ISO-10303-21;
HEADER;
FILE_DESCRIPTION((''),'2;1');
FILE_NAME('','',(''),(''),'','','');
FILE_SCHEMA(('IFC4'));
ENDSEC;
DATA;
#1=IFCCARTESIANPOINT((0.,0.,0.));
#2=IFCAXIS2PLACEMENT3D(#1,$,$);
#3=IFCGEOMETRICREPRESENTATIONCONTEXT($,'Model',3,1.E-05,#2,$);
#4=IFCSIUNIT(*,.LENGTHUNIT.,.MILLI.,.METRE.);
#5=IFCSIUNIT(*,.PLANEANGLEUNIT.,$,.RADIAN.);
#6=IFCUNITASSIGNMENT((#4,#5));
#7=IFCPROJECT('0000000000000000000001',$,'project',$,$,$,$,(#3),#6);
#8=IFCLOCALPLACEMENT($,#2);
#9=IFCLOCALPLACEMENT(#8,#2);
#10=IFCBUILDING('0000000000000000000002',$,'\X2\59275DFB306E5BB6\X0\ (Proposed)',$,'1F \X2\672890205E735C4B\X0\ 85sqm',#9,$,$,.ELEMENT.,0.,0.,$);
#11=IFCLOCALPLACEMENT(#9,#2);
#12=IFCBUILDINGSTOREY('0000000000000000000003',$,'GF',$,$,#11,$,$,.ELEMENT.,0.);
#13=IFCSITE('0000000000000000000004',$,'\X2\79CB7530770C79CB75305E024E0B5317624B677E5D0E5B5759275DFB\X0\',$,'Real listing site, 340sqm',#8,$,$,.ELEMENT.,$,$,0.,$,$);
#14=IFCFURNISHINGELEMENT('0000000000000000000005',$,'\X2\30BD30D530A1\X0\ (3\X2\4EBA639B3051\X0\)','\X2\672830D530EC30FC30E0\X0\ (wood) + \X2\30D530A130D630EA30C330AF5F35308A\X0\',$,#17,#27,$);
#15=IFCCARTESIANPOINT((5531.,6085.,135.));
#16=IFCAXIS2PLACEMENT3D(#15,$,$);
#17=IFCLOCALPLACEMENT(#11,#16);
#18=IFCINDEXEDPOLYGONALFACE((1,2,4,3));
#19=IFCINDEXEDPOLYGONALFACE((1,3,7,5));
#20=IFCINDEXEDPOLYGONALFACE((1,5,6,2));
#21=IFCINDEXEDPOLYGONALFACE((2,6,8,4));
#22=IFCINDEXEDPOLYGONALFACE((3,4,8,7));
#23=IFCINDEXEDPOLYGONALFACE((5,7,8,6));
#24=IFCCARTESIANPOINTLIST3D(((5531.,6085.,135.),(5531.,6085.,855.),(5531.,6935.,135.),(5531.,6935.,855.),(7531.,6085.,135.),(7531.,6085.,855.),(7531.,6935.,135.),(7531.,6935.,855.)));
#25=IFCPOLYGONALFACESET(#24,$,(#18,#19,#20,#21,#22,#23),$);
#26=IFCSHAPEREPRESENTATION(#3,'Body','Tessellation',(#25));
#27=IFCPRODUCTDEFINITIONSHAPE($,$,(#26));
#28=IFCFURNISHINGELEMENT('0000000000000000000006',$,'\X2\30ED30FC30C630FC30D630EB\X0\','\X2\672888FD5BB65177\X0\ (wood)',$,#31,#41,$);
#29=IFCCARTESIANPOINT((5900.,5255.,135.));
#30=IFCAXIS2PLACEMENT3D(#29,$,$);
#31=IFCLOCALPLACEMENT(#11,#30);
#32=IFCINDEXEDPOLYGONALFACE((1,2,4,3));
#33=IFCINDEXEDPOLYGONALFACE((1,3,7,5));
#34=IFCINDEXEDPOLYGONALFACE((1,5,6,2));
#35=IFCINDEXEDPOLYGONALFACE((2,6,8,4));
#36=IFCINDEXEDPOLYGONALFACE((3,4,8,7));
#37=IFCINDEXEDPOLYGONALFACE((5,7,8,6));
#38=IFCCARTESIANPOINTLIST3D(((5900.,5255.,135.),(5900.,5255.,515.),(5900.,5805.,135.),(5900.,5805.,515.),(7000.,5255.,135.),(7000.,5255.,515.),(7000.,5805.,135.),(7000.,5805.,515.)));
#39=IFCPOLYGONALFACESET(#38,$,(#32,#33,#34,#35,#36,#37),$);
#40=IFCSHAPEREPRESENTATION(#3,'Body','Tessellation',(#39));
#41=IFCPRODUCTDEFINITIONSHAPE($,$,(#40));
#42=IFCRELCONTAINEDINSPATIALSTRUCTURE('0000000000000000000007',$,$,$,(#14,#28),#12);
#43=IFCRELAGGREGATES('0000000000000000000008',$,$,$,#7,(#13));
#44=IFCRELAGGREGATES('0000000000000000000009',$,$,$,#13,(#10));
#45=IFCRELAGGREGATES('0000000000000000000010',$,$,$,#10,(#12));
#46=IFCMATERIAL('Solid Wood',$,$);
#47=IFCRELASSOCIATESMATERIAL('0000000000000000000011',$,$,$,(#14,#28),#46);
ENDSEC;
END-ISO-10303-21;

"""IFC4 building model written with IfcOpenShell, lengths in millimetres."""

from ifc_helpers import new_model, si_unit, frame, frame_2d, origin, place, context, project, spatial, rectangle, extrude, material, element, save


model = new_model("IFC4")

# Units and contexts
model_context = context("Model", 3, precision=1e-05, world=origin())
ifc_project = project(units=[si_unit("LENGTHUNIT", "METRE", prefix="MILLI"), si_unit("PLANEANGLEUNIT", "RADIAN")], contexts=[model_context])

# Site, building, storey
site_placement = place(None, origin())
site = spatial("IfcSite", under=ifc_project, at=site_placement, Name="秋田県秋田市下北手松崎字大巻", ObjectType="Real listing site, 340sqm", CompositionType="ELEMENT", RefElevation=0.0)
building_placement = place(site_placement, origin())
building = spatial("IfcBuilding", under=site, at=building_placement, Name="大巻の家 (Proposed)", ObjectType="1F 木造平屋 85sqm", CompositionType="ELEMENT", ElevationOfRefHeight=0.0, ElevationOfTerrain=0.0)
storey_placement = place(building_placement, origin())
storey = spatial("IfcBuildingStorey", under=building, at=storey_placement, Name="GF", CompositionType="ELEMENT", Elevation=0.0)

# Shared definitions
ifc_material_1 = material(Name="Solid Wood")

# Furnishing elements
furnishing_1_placement = place(storey_placement, frame((5531.0, 6085.0, 135.0)))
element("IfcFurnishingElement", 1, at=furnishing_1_placement, inside=storey, material=ifc_material_1, Name="ソファ (3人掛け)", Description="木フレーム (wood) + ファブリック張り", context=model_context, shape_type="SweptSolid", body=[
    extrude(rectangle(XDim=2000.0, YDim=850.0, at=frame_2d((1000.0, 425.0))), frame((5531.0, 6085.0, 135.0)), (0.0, 0.0, 1.0), 720.0),
])
furnishing_2_placement = place(storey_placement, frame((5900.0, 5255.0, 135.0)))
element("IfcFurnishingElement", 2, at=furnishing_2_placement, inside=storey, material=ifc_material_1, Name="ローテーブル", Description="木製家具 (wood)", context=model_context, shape_type="SweptSolid", body=[
    extrude(rectangle(XDim=1100.0, YDim=550.0, at=frame_2d((550.0, 275.0))), frame((5900.0, 5255.0, 135.0)), (0.0, 0.0, 1.0), 380.0),
])

save(model, "model.ifc")
